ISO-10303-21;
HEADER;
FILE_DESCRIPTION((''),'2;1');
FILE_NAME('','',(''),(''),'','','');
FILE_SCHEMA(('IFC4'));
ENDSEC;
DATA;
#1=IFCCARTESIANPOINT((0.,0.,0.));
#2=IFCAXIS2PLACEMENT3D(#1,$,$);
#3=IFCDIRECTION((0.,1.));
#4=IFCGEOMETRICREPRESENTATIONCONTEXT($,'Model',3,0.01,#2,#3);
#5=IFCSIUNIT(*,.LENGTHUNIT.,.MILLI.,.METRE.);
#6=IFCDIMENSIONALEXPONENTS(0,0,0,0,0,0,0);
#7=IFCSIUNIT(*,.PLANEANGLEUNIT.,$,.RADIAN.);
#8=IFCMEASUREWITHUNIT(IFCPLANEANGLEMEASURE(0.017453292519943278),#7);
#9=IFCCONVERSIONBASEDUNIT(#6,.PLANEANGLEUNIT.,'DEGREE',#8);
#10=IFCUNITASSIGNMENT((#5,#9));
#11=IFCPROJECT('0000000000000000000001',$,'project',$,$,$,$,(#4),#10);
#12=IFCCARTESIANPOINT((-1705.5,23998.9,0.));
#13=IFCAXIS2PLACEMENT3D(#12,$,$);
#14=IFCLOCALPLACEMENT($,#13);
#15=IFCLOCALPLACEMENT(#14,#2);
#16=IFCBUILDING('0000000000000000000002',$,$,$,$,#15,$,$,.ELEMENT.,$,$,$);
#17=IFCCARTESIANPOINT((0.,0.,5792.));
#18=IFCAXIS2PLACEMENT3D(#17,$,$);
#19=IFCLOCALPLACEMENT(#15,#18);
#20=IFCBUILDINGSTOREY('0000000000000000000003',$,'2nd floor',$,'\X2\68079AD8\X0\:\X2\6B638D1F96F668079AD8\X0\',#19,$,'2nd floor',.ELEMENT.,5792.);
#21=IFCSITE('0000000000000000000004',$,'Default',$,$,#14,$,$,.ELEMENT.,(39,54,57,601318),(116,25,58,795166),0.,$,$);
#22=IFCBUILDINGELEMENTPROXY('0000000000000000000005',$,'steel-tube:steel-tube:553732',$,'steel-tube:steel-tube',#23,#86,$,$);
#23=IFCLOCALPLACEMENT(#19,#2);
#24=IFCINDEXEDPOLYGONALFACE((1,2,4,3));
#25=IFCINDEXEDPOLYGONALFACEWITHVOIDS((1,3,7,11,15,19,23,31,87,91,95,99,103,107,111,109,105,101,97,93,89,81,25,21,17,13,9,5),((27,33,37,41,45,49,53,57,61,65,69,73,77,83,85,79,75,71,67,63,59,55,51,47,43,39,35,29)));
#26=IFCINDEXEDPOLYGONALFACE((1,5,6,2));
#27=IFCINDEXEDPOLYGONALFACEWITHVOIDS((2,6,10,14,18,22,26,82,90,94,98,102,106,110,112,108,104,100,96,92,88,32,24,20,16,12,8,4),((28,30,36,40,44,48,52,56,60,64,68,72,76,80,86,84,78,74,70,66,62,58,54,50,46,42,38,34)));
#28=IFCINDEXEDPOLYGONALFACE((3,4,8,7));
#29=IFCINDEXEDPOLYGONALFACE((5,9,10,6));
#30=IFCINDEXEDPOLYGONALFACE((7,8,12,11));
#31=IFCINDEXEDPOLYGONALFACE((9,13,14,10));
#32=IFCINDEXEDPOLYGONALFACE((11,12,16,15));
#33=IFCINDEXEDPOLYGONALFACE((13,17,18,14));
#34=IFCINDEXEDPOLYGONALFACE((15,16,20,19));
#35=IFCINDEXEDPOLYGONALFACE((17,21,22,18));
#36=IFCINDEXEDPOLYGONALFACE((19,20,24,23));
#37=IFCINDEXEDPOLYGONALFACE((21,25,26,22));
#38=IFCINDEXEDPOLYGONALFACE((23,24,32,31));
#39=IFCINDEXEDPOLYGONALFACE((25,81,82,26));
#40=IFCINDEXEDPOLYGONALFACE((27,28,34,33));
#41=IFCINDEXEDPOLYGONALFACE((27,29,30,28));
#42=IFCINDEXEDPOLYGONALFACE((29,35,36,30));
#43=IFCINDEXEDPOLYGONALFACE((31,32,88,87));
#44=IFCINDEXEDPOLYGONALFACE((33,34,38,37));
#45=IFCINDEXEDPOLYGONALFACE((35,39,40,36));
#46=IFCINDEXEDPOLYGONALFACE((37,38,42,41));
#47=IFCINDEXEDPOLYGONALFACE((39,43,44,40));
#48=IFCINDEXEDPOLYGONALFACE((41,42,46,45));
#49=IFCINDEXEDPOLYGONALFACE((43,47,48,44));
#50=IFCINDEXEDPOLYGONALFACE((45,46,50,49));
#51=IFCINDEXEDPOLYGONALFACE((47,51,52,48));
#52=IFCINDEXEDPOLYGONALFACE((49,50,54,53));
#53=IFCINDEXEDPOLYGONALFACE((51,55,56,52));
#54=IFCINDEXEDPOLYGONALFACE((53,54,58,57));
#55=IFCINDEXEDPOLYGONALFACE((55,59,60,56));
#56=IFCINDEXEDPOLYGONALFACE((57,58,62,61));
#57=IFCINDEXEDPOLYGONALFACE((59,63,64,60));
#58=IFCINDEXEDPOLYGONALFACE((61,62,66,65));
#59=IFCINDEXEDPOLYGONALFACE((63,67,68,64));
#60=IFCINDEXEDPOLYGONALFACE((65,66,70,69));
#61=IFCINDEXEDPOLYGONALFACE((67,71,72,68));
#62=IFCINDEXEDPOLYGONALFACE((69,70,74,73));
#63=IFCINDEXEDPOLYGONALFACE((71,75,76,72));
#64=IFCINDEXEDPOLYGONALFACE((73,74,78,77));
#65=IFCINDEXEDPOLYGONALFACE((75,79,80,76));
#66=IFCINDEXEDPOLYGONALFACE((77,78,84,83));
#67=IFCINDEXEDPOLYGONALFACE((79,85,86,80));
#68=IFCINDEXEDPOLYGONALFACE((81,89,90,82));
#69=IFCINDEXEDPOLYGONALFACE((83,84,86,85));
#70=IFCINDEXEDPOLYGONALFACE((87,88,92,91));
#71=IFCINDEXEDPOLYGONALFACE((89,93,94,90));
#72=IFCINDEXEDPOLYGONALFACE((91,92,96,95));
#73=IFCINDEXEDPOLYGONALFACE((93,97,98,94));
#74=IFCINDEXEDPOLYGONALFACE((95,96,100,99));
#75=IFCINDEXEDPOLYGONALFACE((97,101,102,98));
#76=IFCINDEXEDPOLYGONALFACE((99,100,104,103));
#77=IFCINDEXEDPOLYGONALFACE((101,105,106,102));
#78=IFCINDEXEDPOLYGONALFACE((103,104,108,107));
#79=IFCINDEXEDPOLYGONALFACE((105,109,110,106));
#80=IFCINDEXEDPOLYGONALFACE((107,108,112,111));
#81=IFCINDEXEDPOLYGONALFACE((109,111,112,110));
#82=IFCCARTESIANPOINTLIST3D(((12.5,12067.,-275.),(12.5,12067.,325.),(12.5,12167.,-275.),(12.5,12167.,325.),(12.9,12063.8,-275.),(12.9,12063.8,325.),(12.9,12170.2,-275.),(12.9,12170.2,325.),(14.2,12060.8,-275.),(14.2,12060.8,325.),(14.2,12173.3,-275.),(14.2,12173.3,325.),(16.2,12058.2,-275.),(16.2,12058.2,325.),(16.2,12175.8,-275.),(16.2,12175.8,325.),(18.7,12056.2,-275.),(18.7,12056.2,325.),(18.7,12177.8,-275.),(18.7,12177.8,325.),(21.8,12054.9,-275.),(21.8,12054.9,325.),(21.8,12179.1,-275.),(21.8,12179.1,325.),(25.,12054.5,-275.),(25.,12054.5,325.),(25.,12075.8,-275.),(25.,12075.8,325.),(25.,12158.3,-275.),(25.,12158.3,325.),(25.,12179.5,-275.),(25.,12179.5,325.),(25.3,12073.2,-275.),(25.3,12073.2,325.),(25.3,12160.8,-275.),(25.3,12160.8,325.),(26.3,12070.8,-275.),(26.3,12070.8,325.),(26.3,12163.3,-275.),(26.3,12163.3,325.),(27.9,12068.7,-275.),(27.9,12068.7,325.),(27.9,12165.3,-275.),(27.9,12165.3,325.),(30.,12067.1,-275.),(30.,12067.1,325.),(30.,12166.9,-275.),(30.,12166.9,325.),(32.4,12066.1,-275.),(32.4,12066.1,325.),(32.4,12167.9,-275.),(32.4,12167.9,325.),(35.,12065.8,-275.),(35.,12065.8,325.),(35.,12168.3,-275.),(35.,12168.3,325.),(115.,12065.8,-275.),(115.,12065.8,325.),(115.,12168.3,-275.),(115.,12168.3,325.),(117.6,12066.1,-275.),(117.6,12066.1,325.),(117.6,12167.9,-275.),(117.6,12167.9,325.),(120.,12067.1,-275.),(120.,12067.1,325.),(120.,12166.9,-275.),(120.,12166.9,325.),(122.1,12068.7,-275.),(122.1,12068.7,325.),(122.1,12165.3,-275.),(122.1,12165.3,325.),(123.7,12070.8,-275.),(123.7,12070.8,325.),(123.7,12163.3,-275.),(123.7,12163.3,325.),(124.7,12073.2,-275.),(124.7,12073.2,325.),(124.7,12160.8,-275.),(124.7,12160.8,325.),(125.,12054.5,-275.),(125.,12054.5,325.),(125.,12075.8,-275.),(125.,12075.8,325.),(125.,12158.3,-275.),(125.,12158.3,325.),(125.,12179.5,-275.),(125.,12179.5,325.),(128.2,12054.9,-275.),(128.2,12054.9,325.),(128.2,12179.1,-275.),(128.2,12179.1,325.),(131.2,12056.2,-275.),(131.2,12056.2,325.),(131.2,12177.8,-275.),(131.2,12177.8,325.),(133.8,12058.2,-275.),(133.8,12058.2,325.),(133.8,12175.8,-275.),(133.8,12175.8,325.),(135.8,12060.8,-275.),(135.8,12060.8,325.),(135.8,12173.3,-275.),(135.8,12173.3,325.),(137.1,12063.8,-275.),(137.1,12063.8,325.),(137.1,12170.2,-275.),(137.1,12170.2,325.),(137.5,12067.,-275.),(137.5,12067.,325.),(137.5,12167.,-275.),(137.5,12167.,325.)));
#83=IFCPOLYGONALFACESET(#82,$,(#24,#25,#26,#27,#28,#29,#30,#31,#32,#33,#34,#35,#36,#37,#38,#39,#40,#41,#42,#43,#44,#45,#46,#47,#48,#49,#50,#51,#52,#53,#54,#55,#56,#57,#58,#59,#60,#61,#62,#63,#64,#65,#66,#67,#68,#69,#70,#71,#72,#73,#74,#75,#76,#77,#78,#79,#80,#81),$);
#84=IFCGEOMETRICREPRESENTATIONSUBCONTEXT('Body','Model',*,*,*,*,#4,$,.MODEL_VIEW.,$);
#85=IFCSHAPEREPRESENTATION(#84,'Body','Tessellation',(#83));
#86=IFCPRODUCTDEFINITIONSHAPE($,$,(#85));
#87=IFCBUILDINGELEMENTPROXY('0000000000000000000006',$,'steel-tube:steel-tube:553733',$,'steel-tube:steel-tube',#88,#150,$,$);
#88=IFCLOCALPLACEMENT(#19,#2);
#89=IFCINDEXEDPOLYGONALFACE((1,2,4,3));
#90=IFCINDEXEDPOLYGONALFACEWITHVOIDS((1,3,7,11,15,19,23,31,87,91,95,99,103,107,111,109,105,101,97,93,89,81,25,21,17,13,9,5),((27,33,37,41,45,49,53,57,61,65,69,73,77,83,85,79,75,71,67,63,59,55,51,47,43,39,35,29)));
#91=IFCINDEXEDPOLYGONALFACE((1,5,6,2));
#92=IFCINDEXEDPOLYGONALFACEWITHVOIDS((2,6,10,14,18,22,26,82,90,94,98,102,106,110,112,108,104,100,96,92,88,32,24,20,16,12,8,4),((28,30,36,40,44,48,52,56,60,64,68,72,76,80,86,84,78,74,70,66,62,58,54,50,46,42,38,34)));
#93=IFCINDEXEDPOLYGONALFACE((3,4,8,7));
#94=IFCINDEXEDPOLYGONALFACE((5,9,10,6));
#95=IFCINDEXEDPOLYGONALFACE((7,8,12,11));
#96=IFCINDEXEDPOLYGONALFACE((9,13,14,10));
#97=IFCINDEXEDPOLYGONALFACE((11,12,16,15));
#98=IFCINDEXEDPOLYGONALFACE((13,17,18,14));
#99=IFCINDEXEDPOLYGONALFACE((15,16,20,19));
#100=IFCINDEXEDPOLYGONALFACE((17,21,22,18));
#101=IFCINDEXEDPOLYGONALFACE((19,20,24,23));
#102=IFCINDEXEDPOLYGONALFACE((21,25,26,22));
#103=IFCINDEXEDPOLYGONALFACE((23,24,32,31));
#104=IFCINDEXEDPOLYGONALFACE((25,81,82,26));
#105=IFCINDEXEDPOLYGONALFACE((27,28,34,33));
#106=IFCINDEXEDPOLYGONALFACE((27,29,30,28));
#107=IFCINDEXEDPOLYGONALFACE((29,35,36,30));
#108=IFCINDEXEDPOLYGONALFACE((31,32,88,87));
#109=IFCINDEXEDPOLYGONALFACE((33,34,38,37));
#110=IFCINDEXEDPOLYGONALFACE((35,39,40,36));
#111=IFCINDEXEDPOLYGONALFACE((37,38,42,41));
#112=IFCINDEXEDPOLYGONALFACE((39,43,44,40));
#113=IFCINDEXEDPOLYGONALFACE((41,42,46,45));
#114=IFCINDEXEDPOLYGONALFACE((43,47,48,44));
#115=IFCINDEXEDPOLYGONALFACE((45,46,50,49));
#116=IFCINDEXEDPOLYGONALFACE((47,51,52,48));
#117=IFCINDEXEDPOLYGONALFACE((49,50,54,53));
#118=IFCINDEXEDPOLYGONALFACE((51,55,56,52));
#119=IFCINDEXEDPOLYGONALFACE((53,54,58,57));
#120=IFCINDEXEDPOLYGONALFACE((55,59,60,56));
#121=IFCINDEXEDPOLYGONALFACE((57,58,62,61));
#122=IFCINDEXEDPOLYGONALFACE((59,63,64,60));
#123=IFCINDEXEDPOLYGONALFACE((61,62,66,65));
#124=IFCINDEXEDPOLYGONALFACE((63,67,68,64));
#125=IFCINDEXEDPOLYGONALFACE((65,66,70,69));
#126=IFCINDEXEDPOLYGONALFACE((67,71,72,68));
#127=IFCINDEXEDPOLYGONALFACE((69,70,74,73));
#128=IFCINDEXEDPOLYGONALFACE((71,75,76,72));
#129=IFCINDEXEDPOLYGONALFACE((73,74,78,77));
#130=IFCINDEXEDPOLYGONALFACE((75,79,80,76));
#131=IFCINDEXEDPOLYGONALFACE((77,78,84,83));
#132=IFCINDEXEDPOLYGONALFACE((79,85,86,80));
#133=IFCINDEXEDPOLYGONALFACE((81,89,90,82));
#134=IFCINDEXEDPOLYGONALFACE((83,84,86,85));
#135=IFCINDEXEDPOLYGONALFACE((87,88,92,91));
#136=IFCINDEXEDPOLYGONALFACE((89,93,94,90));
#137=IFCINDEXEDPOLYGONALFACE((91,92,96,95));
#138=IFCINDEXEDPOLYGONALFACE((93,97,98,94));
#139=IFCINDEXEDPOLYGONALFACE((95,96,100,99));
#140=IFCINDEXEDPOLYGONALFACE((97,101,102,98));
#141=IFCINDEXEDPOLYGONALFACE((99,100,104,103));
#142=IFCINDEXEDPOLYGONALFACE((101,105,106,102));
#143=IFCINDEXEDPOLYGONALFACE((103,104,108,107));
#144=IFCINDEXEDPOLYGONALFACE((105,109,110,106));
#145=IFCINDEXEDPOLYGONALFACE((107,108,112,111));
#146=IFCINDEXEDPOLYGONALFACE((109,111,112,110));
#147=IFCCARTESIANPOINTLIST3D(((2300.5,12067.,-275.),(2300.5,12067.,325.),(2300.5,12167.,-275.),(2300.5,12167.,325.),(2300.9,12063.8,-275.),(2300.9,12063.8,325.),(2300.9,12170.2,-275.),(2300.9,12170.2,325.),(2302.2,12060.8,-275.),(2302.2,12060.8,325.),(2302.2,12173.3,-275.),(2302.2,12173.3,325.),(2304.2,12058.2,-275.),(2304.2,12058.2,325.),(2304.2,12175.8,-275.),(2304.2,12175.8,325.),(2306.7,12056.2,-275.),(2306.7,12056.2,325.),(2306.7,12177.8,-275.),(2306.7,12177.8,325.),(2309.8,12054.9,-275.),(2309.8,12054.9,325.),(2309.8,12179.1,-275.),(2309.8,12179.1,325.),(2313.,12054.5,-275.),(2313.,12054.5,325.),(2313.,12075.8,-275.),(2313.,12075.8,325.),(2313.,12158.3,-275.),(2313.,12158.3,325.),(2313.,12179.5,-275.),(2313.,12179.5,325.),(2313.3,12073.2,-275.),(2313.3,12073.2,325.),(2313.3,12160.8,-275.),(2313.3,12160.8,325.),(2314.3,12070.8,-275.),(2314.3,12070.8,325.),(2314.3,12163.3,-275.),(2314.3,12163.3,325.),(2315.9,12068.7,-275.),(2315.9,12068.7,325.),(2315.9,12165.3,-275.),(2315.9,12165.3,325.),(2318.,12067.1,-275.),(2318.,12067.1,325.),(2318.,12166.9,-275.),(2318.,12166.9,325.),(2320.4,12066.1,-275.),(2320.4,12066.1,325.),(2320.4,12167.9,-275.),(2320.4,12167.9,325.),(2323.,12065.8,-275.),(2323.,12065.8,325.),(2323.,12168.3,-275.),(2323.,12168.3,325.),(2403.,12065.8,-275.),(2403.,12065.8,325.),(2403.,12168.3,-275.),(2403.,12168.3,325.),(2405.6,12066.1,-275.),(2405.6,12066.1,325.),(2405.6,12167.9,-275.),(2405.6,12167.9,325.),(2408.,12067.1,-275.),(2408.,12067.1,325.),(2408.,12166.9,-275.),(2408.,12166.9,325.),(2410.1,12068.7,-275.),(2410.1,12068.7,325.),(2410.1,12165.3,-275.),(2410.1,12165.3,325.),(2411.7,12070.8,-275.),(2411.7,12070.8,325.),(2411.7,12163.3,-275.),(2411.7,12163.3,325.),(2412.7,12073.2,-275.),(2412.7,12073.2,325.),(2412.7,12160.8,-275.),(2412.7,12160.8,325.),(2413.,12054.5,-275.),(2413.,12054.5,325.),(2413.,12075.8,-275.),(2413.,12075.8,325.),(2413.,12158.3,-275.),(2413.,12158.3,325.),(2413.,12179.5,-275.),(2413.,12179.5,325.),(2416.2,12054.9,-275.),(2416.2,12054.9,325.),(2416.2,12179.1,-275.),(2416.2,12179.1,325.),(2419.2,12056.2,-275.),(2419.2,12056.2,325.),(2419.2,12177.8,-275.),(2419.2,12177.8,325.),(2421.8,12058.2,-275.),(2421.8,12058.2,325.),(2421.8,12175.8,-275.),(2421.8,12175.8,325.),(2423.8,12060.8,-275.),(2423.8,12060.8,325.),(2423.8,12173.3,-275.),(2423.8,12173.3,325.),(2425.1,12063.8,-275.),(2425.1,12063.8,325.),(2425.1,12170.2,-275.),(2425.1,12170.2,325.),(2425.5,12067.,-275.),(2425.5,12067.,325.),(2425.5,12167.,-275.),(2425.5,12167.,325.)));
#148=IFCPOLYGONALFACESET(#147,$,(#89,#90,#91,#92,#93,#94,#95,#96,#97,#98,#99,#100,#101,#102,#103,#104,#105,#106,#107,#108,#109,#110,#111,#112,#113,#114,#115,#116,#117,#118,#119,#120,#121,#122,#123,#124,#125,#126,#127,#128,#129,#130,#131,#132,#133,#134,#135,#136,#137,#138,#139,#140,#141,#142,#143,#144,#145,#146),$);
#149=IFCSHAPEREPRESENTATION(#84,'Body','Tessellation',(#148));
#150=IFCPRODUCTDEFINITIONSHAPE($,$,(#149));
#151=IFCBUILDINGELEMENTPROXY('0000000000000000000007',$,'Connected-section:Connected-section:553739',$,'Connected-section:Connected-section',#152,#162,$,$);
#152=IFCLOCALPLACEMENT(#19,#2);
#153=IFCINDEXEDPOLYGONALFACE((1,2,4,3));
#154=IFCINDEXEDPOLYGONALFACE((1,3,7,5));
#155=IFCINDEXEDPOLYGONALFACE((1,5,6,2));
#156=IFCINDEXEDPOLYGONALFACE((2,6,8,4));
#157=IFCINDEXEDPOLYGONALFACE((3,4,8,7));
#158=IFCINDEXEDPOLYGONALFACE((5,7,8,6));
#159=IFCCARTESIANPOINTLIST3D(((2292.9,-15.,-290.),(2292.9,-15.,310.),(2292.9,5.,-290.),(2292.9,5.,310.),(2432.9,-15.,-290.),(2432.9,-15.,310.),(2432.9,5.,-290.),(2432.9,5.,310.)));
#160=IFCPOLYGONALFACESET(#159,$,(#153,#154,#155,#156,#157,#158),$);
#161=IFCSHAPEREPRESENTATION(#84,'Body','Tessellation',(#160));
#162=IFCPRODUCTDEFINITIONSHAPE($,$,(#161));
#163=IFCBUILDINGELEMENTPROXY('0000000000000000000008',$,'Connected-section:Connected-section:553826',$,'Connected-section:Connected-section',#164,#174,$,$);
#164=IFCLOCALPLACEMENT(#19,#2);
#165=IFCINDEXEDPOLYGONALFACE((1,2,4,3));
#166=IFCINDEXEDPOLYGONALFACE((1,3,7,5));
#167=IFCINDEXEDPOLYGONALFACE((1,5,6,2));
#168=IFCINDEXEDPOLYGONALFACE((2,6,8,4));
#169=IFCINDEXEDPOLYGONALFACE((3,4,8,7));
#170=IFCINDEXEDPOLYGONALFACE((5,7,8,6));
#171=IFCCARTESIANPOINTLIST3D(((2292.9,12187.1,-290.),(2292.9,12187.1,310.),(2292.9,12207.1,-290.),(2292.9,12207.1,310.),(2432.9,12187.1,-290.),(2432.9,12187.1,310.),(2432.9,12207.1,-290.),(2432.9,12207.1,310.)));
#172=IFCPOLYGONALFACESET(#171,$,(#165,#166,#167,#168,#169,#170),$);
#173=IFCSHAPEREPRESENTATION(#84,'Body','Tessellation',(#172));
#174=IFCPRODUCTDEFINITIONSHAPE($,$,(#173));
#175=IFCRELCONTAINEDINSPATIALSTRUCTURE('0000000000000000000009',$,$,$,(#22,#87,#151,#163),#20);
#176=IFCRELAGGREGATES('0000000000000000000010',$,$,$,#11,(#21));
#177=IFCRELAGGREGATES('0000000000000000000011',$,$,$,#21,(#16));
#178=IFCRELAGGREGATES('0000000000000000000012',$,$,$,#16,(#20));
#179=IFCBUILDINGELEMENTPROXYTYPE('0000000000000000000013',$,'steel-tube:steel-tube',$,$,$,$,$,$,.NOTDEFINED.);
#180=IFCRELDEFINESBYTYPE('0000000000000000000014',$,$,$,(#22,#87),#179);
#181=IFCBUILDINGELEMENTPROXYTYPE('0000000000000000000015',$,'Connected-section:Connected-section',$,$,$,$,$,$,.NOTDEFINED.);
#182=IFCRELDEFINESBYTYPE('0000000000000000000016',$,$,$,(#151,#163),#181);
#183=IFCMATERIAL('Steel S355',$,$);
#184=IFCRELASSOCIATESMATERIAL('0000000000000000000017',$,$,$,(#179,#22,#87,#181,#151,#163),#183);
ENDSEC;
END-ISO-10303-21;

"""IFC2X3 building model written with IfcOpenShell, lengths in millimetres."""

from ifc_helpers import new_model, entity, si_unit, converted_unit, direction, frame, frame_2d, origin, place, context, subcontext, project, spatial, polyline, circle_curve, parameter, trimmed, segment, composite_curve, rectangle, outline, extrude, source, transform, mapped, material, type_object, type_shapes, element, save


model = new_model("IFC2X3")

# Units and contexts
model_context = context("Model", 3, precision=0.01, world=origin(), true_north=direction((0.0, 1.0)))
body_context = subcontext(model_context, "Body", "Model", "MODEL_VIEW")
ifc_project = project(units=[si_unit("LENGTHUNIT", "METRE", prefix="MILLI"), converted_unit("PLANEANGLEUNIT", "DEGREE", entity("IfcPlaneAngleMeasure", 0.017453292519943278), si_unit("PLANEANGLEUNIT", "RADIAN"), dimensions=[0, 0, 0, 0, 0, 0, 0])], contexts=[model_context])

# Site, building, storey
site_placement = place(None, frame((-1705.5, 23998.9, 0.0)))
site = spatial("IfcSite", under=ifc_project, at=site_placement, Name="Default", CompositionType="ELEMENT", RefLatitude=(39, 54, 57, 601318), RefLongitude=(116, 25, 58, 795166), RefElevation=0.0)
building_placement = place(site_placement, origin())
building = spatial("IfcBuilding", under=site, at=building_placement, CompositionType="ELEMENT")
storey_placement = place(building_placement, frame((0.0, 0.0, 5792.0)))
storey = spatial("IfcBuildingStorey", under=building, at=storey_placement, Name="2nd floor", ObjectType="标高:正负零标高", LongName="2nd floor", CompositionType="ELEMENT", Elevation=5792.0)

# Shared definitions
ifc_material_1 = material(Name="Steel S355")

# Building element proxies
building_element_proxy_type_1 = type_object("IfcBuildingElementProxyType", Name="steel-tube:steel-tube", PredefinedType="NOTDEFINED", material=ifc_material_1)
shared_shape_1 = source(origin(), body_context, "Body", "SweptSolid", [
    extrude(outline(composite_curve([segment(trimmed(circle_curve(frame_2d((50.0, -50.0), x_axis=(1.0, 0.0)), 12.5), [parameter(270.0)], [parameter(0.0)], True, "PARAMETER"), True, "CONTINUOUS"), segment(polyline([(62.5, -50.0), (62.5, 50.0)]), True, "CONTINUOUS"), segment(trimmed(circle_curve(frame_2d((50.0, 50.0), x_axis=(1.0, 0.0)), 12.5), [parameter(0.0)], [parameter(90.0)], True, "PARAMETER"), True, "CONTINUOUS"), segment(polyline([(50.0, 62.5), (-50.0, 62.5)]), True, "CONTINUOUS"), segment(trimmed(circle_curve(frame_2d((-50.0, 50.0), x_axis=(1.0, 0.0)), 12.5), [parameter(90.0)], [parameter(180.0)], True, "PARAMETER"), True, "CONTINUOUS"), segment(polyline([(-62.5, 50.0), (-62.5, -50.0)]), True, "CONTINUOUS"), segment(trimmed(circle_curve(frame_2d((-50.0, -50.0), x_axis=(1.0, 0.0)), 12.5), [parameter(180.0)], [parameter(270.0)], True, "PARAMETER"), True, "CONTINUOUS"), segment(polyline([(-50.0, -62.5), (50.0, -62.5)]), True, "CONTINUOUS")], self_intersect=False), holes=[composite_curve([segment(trimmed(circle_curve(frame_2d((-41.2, 40.0), x_axis=(1.0, 0.0)), 10.0), [parameter(90.0)], [parameter(180.0)], True, "PARAMETER"), False, "CONTINUOUS"), segment(polyline([(-41.3, 50.0), (41.2, 50.0)]), True, "CONTINUOUS"), segment(trimmed(circle_curve(frame_2d((41.2, 40.0), x_axis=(1.0, 0.0)), 10.0), [parameter(0.0)], [parameter(90.0)], True, "PARAMETER"), False, "CONTINUOUS"), segment(polyline([(51.2, 40.0), (51.2, -40.0)]), True, "CONTINUOUS"), segment(trimmed(circle_curve(frame_2d((41.2, -40.0), x_axis=(1.0, 0.0)), 10.0), [parameter(270.0)], [parameter(360.0)], True, "PARAMETER"), False, "CONTINUOUS"), segment(polyline([(41.2, -50.0), (-41.3, -50.0)]), True, "CONTINUOUS"), segment(trimmed(circle_curve(frame_2d((-41.3, -40.0), x_axis=(1.0, 0.0)), 10.0), [parameter(180.0)], [parameter(270.0)], True, "PARAMETER"), False, "CONTINUOUS"), segment(polyline([(-51.3, -40.0), (-51.3, 40.0)]), True, "CONTINUOUS")], self_intersect=False)]), frame((62.5, 62.5, -175.0)), (0.0, 0.0, 1.0), 600.0),
])
type_shapes(building_element_proxy_type_1, [shared_shape_1])
for number, where, z_axis, x_axis, name in (
    (1, (12.5, 12179.5, -100.0), (0.0, 0.0, 1.0), (0.0, -1.0, 0.0), "steel-tube:steel-tube:553732"),
    (2, (2300.5, 12179.5, -100.0), (0.0, 0.0, 1.0), (0.0, -1.0, 0.0), "steel-tube:steel-tube:553733"),
):
    element("IfcBuildingElementProxy", number, at=place(storey_placement, frame(where, z_axis=z_axis, x_axis=x_axis)), inside=storey, type_object=building_element_proxy_type_1, material=ifc_material_1, Name=name, ObjectType="steel-tube:steel-tube", context=body_context, shape_type="MappedRepresentation", body=[
        mapped(shared_shape_1, transform((0.0, 0.0, 0.0), scale=1.0)),
    ])
building_element_proxy_type_2 = type_object("IfcBuildingElementProxyType", Name="Connected-section:Connected-section", PredefinedType="NOTDEFINED", material=ifc_material_1)
shared_shape_2 = source(origin(), body_context, "Body", "SweptSolid", [
    extrude(rectangle(XDim=20.0, YDim=140.0, at=frame_2d((0.0, 0.0), x_axis=(1.0, 0.0))), frame((70.0, 10.0, 0.0), z_axis=(0.0, 0.0, 1.0), x_axis=(0.0, 1.0, 0.0)), (0.0, 0.0, 1.0), 600.0),
])
type_shapes(building_element_proxy_type_2, [shared_shape_2])
for number, where, name in (
    (3, (2292.9, -15.0, -290.0), "Connected-section:Connected-section:553739"),
    (4, (2292.9, 12187.1, -290.0), "Connected-section:Connected-section:553826"),
):
    element("IfcBuildingElementProxy", number, at=place(storey_placement, frame(where)), inside=storey, type_object=building_element_proxy_type_2, material=ifc_material_1, Name=name, ObjectType="Connected-section:Connected-section", context=body_context, shape_type="MappedRepresentation", body=[
        mapped(shared_shape_2, transform((0.0, 0.0, 0.0), scale=1.0)),
    ])

save(model, "model.ifc")
